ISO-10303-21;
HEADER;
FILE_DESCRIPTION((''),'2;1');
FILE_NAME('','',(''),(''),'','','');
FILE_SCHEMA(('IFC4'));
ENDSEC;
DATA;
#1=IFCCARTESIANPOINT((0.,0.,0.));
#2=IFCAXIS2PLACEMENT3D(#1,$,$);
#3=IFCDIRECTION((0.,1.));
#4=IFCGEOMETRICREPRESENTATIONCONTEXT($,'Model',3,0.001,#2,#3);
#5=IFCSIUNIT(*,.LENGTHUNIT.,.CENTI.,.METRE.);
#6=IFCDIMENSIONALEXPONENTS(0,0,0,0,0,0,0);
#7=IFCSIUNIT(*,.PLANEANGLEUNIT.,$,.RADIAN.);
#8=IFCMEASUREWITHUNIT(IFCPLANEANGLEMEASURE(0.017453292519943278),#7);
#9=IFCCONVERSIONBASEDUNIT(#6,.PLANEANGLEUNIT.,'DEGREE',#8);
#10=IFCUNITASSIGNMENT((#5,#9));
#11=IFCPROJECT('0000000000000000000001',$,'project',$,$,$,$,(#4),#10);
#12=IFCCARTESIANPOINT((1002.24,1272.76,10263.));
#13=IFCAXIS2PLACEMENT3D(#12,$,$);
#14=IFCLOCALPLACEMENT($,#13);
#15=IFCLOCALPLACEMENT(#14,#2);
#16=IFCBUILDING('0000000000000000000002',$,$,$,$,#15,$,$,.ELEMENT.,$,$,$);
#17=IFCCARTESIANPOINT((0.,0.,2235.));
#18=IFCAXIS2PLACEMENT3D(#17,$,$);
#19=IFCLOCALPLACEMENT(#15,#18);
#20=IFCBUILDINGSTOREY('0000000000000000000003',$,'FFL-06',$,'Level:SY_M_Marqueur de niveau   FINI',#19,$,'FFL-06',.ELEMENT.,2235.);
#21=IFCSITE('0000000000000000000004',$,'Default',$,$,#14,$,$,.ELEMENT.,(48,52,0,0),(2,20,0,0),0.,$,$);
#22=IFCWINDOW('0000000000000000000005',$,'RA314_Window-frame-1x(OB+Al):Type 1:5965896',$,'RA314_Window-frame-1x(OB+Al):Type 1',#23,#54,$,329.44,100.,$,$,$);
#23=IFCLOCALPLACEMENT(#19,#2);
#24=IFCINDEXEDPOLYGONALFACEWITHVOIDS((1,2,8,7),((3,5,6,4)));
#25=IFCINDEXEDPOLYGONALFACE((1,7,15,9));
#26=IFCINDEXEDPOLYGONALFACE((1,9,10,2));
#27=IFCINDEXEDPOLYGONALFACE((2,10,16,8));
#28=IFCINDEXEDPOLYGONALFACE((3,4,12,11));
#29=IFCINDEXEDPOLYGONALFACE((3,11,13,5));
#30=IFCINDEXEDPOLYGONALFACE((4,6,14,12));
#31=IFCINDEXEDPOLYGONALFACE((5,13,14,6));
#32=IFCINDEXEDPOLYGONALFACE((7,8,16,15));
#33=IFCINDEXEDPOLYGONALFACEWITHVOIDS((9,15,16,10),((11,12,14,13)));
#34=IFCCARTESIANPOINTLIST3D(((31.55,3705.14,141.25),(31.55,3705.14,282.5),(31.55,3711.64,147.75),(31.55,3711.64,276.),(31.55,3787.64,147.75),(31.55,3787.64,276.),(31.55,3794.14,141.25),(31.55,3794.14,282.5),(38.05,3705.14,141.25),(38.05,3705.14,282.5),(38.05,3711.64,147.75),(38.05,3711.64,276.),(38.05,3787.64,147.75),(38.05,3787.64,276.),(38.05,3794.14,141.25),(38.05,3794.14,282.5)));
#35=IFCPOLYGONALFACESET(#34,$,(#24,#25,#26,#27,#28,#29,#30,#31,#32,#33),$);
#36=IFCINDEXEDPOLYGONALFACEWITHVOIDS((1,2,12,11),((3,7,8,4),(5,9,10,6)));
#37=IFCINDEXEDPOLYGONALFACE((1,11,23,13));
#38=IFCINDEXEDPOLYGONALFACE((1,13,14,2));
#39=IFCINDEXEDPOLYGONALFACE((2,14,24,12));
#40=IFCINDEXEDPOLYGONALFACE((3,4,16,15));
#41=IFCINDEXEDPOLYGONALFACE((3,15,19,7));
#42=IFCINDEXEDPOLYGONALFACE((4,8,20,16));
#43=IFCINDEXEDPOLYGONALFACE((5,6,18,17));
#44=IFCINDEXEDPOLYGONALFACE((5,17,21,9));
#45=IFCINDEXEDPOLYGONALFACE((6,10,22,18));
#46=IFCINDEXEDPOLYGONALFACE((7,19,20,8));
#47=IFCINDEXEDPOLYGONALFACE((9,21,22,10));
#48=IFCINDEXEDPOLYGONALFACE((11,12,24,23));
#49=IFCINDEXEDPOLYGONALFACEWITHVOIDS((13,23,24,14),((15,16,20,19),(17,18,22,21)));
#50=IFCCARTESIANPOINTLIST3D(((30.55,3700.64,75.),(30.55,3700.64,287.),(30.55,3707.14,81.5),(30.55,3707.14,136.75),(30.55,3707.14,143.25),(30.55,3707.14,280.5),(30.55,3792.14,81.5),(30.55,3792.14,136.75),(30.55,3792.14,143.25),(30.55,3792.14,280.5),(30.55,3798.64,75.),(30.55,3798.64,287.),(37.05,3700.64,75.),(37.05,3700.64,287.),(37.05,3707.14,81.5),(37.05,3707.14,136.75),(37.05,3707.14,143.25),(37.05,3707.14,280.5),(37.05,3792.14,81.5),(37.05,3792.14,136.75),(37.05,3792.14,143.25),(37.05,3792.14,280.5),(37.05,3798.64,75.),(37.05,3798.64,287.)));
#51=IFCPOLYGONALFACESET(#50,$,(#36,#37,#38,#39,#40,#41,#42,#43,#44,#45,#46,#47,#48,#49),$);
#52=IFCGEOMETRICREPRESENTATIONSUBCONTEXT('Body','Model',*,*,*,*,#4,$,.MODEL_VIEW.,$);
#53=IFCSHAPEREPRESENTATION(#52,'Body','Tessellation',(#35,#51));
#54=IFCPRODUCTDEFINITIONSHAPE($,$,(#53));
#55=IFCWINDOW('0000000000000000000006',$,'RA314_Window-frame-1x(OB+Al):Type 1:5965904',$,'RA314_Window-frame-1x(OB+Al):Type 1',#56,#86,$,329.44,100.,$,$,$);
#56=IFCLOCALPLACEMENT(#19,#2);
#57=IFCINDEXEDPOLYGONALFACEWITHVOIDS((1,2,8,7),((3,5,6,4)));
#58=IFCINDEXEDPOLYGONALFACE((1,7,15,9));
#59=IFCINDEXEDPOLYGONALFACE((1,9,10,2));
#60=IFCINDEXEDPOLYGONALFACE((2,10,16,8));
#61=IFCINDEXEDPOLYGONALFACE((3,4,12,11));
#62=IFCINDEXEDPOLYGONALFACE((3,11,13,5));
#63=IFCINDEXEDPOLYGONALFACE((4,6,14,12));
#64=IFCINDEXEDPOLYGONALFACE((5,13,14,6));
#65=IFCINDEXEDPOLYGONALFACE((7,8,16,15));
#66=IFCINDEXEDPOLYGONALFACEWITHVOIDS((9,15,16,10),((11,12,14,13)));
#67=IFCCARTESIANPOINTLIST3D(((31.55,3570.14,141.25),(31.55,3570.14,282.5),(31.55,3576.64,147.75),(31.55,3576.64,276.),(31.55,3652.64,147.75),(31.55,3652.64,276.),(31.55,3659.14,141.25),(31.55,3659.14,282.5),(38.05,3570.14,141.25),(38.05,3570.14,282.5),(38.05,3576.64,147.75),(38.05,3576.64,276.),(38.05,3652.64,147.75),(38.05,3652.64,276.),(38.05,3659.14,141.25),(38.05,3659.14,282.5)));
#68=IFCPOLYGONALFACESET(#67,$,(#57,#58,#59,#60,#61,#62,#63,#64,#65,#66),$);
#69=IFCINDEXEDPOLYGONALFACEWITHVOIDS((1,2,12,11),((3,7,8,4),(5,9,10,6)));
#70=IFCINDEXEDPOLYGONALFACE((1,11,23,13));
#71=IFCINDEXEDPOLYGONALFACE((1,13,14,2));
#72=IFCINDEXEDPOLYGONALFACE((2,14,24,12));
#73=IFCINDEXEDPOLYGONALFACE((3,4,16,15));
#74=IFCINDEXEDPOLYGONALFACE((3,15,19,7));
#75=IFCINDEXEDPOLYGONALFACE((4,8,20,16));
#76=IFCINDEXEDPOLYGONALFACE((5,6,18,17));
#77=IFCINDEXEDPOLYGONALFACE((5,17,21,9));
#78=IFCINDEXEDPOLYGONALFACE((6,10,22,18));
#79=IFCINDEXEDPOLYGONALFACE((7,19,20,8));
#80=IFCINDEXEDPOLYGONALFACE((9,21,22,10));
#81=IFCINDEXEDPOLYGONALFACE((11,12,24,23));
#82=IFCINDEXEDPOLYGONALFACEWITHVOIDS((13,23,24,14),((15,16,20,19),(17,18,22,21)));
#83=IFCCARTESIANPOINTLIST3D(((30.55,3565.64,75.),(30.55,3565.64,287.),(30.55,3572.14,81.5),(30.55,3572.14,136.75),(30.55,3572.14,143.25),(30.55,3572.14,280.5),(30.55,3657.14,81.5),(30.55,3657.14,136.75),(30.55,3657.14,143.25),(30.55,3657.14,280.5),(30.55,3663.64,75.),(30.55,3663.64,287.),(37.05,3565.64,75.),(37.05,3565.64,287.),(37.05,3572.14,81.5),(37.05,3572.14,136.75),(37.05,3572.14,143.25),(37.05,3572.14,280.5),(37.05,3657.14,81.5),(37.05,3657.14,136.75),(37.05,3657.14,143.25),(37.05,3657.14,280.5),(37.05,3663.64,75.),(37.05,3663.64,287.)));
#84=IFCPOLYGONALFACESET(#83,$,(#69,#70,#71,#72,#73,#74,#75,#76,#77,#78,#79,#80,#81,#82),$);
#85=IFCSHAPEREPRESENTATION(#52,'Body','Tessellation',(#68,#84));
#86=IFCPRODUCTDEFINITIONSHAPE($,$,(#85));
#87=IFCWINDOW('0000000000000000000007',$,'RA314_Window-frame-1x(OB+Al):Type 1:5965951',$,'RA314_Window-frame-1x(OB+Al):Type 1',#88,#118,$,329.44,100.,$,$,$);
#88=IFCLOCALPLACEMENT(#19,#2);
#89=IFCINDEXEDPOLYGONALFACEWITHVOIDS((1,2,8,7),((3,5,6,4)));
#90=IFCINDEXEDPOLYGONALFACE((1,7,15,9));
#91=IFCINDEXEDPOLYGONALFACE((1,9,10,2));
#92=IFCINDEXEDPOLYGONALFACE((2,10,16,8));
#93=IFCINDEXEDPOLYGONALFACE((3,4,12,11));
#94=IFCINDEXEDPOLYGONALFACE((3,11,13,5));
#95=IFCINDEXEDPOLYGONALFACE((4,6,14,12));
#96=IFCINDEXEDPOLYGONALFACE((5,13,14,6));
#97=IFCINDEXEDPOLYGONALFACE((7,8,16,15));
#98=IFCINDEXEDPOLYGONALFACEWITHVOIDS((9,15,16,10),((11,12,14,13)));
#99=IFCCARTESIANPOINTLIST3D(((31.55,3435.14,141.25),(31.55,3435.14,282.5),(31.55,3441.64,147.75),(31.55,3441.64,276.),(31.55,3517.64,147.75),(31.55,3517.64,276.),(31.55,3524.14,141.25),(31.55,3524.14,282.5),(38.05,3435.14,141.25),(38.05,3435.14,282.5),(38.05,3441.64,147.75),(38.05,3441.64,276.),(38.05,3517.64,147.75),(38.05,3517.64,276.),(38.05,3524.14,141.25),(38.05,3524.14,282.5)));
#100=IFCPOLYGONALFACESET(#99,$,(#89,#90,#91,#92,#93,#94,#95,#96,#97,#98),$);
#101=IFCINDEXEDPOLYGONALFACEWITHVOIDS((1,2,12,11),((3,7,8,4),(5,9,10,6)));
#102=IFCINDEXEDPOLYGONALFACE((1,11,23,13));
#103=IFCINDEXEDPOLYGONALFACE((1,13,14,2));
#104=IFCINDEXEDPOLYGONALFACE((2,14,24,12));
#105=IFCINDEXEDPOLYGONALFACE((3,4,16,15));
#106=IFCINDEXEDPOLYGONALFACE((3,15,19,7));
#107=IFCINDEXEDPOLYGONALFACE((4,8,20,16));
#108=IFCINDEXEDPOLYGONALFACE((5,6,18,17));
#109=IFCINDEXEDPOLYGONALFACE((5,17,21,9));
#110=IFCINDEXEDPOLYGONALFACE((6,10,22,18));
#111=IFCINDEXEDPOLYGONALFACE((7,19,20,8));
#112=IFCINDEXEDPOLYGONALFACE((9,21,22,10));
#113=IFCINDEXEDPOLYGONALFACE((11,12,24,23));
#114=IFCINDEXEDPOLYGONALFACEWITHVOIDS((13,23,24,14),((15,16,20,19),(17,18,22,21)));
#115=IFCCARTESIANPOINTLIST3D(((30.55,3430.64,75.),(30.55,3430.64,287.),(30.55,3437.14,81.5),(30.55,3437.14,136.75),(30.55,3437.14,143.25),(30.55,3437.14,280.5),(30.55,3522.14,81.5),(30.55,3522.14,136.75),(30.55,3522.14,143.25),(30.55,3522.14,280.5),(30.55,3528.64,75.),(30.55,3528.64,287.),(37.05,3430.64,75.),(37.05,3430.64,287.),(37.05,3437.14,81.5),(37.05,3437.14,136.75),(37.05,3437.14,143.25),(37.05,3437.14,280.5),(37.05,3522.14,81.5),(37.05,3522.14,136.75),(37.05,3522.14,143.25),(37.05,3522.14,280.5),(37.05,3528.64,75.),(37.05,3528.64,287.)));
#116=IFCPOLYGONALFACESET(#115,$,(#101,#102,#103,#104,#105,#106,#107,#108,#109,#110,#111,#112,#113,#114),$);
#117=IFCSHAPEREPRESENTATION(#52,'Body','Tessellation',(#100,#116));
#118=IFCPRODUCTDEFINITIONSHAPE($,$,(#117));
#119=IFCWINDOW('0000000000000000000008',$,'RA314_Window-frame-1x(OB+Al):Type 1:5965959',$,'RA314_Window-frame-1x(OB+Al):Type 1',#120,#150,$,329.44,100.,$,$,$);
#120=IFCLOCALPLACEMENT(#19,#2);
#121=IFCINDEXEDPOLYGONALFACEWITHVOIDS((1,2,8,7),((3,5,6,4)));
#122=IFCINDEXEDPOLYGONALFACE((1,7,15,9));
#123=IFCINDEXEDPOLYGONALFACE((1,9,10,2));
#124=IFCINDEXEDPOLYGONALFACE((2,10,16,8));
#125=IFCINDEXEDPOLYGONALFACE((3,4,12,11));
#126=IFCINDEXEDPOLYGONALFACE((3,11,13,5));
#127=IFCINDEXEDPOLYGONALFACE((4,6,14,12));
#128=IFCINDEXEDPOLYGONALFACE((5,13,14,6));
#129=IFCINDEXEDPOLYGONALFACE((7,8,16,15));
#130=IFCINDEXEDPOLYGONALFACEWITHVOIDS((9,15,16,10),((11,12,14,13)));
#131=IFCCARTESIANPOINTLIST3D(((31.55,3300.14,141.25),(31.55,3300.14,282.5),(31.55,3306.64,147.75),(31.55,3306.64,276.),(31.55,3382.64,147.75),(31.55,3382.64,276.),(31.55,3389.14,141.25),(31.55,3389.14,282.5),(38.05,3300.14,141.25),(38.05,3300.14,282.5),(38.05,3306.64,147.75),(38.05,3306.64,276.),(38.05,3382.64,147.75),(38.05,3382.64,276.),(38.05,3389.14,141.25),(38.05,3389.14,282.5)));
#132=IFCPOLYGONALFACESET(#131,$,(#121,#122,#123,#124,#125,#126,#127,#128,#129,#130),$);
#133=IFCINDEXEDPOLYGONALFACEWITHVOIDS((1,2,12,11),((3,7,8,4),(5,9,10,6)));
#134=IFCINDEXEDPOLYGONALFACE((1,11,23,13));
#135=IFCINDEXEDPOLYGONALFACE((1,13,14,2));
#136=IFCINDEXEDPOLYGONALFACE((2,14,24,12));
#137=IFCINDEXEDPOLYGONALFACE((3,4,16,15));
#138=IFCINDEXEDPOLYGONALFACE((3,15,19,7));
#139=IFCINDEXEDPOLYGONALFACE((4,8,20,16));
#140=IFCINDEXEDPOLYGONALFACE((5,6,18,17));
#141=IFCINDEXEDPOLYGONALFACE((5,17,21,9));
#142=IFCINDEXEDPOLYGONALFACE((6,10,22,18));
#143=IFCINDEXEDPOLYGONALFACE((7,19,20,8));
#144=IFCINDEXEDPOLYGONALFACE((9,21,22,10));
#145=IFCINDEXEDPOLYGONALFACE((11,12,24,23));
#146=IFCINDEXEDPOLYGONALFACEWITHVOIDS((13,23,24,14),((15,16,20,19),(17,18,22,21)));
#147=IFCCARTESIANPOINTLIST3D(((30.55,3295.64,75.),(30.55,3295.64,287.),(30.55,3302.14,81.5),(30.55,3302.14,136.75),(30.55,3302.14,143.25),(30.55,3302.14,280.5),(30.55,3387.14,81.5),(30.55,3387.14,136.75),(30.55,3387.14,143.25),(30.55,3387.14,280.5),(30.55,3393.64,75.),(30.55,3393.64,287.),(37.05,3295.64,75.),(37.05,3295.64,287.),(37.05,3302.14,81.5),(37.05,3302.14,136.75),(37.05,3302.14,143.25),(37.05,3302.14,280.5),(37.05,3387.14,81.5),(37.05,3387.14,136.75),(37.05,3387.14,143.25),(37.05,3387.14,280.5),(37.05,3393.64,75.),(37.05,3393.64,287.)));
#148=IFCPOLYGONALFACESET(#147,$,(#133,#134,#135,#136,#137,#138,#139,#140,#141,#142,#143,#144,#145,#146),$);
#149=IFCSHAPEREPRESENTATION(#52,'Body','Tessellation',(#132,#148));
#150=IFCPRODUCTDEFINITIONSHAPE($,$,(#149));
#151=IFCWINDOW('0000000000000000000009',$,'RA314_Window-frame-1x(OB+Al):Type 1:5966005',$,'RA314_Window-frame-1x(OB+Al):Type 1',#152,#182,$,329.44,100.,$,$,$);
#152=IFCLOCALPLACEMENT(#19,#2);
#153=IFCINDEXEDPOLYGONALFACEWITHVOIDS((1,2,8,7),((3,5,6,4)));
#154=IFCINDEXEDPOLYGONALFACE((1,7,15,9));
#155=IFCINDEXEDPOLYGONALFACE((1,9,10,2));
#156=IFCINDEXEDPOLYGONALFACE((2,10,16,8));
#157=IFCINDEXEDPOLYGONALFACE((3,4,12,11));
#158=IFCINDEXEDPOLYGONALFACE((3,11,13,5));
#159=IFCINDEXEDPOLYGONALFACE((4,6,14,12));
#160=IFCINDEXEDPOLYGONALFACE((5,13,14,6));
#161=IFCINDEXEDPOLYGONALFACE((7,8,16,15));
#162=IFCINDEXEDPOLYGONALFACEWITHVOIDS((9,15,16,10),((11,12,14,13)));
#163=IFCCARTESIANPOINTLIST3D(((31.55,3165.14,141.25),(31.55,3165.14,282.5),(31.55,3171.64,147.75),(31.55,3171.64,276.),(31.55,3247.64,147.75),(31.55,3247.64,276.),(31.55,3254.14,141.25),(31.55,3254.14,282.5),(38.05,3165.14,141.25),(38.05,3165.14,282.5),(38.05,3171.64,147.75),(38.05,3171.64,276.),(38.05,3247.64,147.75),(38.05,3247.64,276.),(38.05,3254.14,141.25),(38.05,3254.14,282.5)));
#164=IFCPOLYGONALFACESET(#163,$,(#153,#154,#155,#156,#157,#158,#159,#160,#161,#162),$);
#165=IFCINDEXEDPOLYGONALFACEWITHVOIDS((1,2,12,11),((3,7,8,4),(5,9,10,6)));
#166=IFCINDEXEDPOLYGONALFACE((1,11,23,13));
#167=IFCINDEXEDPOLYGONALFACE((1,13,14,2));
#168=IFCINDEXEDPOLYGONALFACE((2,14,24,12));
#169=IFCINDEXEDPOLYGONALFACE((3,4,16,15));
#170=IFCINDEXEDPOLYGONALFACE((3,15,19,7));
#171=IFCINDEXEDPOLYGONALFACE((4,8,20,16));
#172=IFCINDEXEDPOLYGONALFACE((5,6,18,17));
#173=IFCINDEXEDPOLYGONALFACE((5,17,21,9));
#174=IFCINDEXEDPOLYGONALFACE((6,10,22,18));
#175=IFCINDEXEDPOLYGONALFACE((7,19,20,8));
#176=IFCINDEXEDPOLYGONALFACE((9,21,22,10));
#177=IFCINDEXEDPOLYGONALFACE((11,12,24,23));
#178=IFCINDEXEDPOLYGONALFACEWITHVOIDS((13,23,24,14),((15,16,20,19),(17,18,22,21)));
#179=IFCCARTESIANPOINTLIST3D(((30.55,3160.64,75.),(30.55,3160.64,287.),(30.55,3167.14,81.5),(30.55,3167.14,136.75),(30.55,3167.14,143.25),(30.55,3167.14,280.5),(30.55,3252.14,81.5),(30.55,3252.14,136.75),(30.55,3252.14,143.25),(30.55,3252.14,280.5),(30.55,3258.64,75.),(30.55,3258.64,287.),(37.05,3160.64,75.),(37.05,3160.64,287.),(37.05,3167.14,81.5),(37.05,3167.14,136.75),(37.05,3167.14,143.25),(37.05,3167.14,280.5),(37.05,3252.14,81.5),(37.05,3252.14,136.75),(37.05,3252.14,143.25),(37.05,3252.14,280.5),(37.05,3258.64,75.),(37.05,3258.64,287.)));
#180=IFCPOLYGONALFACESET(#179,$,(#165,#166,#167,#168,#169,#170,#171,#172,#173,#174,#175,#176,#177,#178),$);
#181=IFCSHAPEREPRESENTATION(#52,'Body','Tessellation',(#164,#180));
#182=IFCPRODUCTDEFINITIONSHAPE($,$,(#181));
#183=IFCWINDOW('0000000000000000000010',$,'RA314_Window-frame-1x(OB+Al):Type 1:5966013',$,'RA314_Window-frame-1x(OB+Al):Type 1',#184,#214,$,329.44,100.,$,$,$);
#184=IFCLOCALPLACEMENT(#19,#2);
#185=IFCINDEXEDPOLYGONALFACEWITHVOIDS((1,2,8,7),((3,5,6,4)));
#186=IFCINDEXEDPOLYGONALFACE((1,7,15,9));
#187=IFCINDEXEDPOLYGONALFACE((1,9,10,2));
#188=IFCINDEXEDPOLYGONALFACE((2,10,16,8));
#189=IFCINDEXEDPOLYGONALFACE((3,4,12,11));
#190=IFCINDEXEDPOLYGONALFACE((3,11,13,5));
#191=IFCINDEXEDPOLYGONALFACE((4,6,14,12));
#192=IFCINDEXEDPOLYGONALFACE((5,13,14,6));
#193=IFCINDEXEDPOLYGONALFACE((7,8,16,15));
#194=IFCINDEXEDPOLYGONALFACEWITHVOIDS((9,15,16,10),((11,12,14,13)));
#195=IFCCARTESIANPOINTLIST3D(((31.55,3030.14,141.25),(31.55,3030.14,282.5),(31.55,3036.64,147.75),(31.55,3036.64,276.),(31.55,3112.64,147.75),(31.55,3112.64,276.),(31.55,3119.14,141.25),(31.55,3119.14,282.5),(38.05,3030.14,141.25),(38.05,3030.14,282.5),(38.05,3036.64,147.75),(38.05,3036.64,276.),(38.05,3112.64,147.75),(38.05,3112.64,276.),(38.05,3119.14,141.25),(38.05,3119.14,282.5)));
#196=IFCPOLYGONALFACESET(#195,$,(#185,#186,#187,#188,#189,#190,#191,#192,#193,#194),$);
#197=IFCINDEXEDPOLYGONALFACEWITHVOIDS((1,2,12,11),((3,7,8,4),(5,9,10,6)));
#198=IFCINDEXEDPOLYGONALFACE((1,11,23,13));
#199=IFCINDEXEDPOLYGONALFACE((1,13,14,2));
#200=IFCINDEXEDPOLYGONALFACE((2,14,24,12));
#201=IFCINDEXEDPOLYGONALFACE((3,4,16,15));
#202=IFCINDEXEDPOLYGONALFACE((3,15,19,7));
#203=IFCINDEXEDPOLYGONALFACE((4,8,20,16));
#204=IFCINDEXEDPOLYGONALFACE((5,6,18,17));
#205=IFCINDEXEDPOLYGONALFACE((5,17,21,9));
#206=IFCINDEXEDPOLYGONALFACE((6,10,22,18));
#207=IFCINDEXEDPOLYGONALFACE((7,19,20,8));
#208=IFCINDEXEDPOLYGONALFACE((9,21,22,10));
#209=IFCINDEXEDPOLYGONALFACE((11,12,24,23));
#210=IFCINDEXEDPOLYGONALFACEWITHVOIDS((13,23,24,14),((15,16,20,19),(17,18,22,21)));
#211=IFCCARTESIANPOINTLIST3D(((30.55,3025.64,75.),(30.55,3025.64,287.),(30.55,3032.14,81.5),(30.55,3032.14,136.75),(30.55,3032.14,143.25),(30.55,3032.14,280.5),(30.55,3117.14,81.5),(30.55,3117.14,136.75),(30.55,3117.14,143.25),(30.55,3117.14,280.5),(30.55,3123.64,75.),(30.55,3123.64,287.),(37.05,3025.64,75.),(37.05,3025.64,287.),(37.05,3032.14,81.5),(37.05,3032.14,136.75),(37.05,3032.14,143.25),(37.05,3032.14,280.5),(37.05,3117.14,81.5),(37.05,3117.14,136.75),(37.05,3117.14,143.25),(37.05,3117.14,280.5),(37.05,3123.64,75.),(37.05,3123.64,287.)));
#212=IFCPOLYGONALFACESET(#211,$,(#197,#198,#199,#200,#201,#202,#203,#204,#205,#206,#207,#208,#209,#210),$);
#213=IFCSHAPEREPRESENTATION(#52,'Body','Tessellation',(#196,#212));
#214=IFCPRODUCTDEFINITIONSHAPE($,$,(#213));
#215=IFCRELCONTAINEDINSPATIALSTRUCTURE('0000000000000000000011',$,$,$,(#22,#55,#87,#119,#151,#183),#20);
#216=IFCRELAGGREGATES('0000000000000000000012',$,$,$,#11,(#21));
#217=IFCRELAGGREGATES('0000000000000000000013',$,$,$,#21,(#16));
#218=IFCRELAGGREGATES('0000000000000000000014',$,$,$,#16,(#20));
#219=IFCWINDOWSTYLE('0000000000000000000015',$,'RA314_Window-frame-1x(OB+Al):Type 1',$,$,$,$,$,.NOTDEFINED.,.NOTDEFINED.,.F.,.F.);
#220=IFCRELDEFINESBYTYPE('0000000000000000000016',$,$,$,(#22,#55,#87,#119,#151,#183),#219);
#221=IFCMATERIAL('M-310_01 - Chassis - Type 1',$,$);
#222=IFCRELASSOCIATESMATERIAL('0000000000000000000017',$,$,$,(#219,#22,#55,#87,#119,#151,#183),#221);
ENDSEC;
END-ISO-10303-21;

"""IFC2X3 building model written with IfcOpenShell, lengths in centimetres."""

from ifc_helpers import new_model, entity, si_unit, converted_unit, direction, frame, origin, place, context, subcontext, project, spatial, polyline, outline, extrude, source, transform, mapped, material, type_object, type_shapes, element, save


model = new_model("IFC2X3")

# Units and contexts
model_context = context("Model", 3, precision=0.001, world=origin(), true_north=direction((0.0, 1.0)))
body_context = subcontext(model_context, "Body", "Model", "MODEL_VIEW")
ifc_project = project(units=[si_unit("LENGTHUNIT", "METRE", prefix="CENTI"), converted_unit("PLANEANGLEUNIT", "DEGREE", entity("IfcPlaneAngleMeasure", 0.017453292519943278), si_unit("PLANEANGLEUNIT", "RADIAN"), dimensions=[0, 0, 0, 0, 0, 0, 0])], contexts=[model_context])

# Site, building, storey
site_placement = place(None, frame((1002.24, 1272.76, 10263.0)))
site = spatial("IfcSite", under=ifc_project, at=site_placement, Name="Default", CompositionType="ELEMENT", RefLatitude=(48, 52, 0, 0), RefLongitude=(2, 20, 0, 0), RefElevation=0.0)
building_placement = place(site_placement, origin())
building = spatial("IfcBuilding", under=site, at=building_placement, CompositionType="ELEMENT")
storey_placement = place(building_placement, frame((0.0, 0.0, 2235.0)))
storey = spatial("IfcBuildingStorey", under=building, at=storey_placement, Name="FFL-06", ObjectType="Level:SY_M_Marqueur de niveau   FINI", LongName="FFL-06", CompositionType="ELEMENT", Elevation=2235.0)

# Windows
ifc_material_1 = material(Name="M-310_01 - Chassis - Type 1")
window_style_1 = type_object("IfcWindowStyle", Name="RA314_Window-frame-1x(OB+Al):Type 1", ConstructionType="NOTDEFINED", OperationType="NOTDEFINED", ParameterTakesPrecedence=False, Sizeable=False, material=ifc_material_1)
shared_shape_1 = source(origin(), body_context, "Body", "SweptSolid", [
    extrude(outline(polyline([(-70.62, -44.5), (70.62, -44.5), (70.62, 44.5), (-70.62, 44.5), (-70.62, -44.5)]), holes=[polyline([(-64.12, -38.0), (-64.12, 38.0), (64.12, 38.0), (64.12, -38.0), (-64.12, -38.0)])]), frame((0.0, 1.0, 136.87), z_axis=(0.0, 1.0, 0.0), x_axis=(0.0, 0.0, -1.0)), (0.0, 0.0, 1.0), 6.5),
    extrude(outline(polyline([(-106.0, -49.0), (106.0, -49.0), (106.0, 49.0), (-106.0, 49.0), (-106.0, -49.0)]), holes=[polyline([(-99.5, -42.5), (-99.5, 42.5), (37.75, 42.5), (37.75, -42.5), (-99.5, -42.5)]), polyline([(44.25, -42.5), (44.25, 42.5), (99.5, 42.5), (99.5, -42.5), (44.25, -42.5)])]), frame((0.0, 0.0, 106.0), z_axis=(0.0, 1.0, 0.0), x_axis=(0.0, 0.0, -1.0)), (0.0, 0.0, 1.0), 6.5),
])
type_shapes(window_style_1, [shared_shape_1])
for number, where, z_axis, x_axis, name in (
    (1, (30.55, 3749.64, 75.0), (0.0, 0.0, 1.0), (0.0, -1.0, 0.0), "RA314_Window-frame-1x(OB+Al):Type 1:5965896"),
    (2, (30.55, 3614.64, 75.0), (0.0, 0.0, 1.0), (0.0, -1.0, 0.0), "RA314_Window-frame-1x(OB+Al):Type 1:5965904"),
    (3, (30.55, 3479.64, 75.0), (0.0, 0.0, 1.0), (0.0, -1.0, 0.0), "RA314_Window-frame-1x(OB+Al):Type 1:5965951"),
    (4, (30.55, 3344.64, 75.0), (0.0, 0.0, 1.0), (0.0, -1.0, 0.0), "RA314_Window-frame-1x(OB+Al):Type 1:5965959"),
    (5, (30.55, 3209.64, 75.0), (0.0, 0.0, 1.0), (0.0, -1.0, 0.0), "RA314_Window-frame-1x(OB+Al):Type 1:5966005"),
    (6, (30.55, 3074.64, 75.0), (0.0, 0.0, 1.0), (0.0, -1.0, 0.0), "RA314_Window-frame-1x(OB+Al):Type 1:5966013"),
):
    element("IfcWindow", number, at=place(storey_placement, frame(where, z_axis=z_axis, x_axis=x_axis)), inside=storey, type_object=window_style_1, material=ifc_material_1, Name=name, ObjectType="RA314_Window-frame-1x(OB+Al):Type 1", OverallHeight=329.44, OverallWidth=100.0, context=body_context, shape_type="MappedRepresentation", body=[
        mapped(shared_shape_1, transform((0.0, 0.0, 0.0), scale=1.0)),
    ])

save(model, "model.ifc")
